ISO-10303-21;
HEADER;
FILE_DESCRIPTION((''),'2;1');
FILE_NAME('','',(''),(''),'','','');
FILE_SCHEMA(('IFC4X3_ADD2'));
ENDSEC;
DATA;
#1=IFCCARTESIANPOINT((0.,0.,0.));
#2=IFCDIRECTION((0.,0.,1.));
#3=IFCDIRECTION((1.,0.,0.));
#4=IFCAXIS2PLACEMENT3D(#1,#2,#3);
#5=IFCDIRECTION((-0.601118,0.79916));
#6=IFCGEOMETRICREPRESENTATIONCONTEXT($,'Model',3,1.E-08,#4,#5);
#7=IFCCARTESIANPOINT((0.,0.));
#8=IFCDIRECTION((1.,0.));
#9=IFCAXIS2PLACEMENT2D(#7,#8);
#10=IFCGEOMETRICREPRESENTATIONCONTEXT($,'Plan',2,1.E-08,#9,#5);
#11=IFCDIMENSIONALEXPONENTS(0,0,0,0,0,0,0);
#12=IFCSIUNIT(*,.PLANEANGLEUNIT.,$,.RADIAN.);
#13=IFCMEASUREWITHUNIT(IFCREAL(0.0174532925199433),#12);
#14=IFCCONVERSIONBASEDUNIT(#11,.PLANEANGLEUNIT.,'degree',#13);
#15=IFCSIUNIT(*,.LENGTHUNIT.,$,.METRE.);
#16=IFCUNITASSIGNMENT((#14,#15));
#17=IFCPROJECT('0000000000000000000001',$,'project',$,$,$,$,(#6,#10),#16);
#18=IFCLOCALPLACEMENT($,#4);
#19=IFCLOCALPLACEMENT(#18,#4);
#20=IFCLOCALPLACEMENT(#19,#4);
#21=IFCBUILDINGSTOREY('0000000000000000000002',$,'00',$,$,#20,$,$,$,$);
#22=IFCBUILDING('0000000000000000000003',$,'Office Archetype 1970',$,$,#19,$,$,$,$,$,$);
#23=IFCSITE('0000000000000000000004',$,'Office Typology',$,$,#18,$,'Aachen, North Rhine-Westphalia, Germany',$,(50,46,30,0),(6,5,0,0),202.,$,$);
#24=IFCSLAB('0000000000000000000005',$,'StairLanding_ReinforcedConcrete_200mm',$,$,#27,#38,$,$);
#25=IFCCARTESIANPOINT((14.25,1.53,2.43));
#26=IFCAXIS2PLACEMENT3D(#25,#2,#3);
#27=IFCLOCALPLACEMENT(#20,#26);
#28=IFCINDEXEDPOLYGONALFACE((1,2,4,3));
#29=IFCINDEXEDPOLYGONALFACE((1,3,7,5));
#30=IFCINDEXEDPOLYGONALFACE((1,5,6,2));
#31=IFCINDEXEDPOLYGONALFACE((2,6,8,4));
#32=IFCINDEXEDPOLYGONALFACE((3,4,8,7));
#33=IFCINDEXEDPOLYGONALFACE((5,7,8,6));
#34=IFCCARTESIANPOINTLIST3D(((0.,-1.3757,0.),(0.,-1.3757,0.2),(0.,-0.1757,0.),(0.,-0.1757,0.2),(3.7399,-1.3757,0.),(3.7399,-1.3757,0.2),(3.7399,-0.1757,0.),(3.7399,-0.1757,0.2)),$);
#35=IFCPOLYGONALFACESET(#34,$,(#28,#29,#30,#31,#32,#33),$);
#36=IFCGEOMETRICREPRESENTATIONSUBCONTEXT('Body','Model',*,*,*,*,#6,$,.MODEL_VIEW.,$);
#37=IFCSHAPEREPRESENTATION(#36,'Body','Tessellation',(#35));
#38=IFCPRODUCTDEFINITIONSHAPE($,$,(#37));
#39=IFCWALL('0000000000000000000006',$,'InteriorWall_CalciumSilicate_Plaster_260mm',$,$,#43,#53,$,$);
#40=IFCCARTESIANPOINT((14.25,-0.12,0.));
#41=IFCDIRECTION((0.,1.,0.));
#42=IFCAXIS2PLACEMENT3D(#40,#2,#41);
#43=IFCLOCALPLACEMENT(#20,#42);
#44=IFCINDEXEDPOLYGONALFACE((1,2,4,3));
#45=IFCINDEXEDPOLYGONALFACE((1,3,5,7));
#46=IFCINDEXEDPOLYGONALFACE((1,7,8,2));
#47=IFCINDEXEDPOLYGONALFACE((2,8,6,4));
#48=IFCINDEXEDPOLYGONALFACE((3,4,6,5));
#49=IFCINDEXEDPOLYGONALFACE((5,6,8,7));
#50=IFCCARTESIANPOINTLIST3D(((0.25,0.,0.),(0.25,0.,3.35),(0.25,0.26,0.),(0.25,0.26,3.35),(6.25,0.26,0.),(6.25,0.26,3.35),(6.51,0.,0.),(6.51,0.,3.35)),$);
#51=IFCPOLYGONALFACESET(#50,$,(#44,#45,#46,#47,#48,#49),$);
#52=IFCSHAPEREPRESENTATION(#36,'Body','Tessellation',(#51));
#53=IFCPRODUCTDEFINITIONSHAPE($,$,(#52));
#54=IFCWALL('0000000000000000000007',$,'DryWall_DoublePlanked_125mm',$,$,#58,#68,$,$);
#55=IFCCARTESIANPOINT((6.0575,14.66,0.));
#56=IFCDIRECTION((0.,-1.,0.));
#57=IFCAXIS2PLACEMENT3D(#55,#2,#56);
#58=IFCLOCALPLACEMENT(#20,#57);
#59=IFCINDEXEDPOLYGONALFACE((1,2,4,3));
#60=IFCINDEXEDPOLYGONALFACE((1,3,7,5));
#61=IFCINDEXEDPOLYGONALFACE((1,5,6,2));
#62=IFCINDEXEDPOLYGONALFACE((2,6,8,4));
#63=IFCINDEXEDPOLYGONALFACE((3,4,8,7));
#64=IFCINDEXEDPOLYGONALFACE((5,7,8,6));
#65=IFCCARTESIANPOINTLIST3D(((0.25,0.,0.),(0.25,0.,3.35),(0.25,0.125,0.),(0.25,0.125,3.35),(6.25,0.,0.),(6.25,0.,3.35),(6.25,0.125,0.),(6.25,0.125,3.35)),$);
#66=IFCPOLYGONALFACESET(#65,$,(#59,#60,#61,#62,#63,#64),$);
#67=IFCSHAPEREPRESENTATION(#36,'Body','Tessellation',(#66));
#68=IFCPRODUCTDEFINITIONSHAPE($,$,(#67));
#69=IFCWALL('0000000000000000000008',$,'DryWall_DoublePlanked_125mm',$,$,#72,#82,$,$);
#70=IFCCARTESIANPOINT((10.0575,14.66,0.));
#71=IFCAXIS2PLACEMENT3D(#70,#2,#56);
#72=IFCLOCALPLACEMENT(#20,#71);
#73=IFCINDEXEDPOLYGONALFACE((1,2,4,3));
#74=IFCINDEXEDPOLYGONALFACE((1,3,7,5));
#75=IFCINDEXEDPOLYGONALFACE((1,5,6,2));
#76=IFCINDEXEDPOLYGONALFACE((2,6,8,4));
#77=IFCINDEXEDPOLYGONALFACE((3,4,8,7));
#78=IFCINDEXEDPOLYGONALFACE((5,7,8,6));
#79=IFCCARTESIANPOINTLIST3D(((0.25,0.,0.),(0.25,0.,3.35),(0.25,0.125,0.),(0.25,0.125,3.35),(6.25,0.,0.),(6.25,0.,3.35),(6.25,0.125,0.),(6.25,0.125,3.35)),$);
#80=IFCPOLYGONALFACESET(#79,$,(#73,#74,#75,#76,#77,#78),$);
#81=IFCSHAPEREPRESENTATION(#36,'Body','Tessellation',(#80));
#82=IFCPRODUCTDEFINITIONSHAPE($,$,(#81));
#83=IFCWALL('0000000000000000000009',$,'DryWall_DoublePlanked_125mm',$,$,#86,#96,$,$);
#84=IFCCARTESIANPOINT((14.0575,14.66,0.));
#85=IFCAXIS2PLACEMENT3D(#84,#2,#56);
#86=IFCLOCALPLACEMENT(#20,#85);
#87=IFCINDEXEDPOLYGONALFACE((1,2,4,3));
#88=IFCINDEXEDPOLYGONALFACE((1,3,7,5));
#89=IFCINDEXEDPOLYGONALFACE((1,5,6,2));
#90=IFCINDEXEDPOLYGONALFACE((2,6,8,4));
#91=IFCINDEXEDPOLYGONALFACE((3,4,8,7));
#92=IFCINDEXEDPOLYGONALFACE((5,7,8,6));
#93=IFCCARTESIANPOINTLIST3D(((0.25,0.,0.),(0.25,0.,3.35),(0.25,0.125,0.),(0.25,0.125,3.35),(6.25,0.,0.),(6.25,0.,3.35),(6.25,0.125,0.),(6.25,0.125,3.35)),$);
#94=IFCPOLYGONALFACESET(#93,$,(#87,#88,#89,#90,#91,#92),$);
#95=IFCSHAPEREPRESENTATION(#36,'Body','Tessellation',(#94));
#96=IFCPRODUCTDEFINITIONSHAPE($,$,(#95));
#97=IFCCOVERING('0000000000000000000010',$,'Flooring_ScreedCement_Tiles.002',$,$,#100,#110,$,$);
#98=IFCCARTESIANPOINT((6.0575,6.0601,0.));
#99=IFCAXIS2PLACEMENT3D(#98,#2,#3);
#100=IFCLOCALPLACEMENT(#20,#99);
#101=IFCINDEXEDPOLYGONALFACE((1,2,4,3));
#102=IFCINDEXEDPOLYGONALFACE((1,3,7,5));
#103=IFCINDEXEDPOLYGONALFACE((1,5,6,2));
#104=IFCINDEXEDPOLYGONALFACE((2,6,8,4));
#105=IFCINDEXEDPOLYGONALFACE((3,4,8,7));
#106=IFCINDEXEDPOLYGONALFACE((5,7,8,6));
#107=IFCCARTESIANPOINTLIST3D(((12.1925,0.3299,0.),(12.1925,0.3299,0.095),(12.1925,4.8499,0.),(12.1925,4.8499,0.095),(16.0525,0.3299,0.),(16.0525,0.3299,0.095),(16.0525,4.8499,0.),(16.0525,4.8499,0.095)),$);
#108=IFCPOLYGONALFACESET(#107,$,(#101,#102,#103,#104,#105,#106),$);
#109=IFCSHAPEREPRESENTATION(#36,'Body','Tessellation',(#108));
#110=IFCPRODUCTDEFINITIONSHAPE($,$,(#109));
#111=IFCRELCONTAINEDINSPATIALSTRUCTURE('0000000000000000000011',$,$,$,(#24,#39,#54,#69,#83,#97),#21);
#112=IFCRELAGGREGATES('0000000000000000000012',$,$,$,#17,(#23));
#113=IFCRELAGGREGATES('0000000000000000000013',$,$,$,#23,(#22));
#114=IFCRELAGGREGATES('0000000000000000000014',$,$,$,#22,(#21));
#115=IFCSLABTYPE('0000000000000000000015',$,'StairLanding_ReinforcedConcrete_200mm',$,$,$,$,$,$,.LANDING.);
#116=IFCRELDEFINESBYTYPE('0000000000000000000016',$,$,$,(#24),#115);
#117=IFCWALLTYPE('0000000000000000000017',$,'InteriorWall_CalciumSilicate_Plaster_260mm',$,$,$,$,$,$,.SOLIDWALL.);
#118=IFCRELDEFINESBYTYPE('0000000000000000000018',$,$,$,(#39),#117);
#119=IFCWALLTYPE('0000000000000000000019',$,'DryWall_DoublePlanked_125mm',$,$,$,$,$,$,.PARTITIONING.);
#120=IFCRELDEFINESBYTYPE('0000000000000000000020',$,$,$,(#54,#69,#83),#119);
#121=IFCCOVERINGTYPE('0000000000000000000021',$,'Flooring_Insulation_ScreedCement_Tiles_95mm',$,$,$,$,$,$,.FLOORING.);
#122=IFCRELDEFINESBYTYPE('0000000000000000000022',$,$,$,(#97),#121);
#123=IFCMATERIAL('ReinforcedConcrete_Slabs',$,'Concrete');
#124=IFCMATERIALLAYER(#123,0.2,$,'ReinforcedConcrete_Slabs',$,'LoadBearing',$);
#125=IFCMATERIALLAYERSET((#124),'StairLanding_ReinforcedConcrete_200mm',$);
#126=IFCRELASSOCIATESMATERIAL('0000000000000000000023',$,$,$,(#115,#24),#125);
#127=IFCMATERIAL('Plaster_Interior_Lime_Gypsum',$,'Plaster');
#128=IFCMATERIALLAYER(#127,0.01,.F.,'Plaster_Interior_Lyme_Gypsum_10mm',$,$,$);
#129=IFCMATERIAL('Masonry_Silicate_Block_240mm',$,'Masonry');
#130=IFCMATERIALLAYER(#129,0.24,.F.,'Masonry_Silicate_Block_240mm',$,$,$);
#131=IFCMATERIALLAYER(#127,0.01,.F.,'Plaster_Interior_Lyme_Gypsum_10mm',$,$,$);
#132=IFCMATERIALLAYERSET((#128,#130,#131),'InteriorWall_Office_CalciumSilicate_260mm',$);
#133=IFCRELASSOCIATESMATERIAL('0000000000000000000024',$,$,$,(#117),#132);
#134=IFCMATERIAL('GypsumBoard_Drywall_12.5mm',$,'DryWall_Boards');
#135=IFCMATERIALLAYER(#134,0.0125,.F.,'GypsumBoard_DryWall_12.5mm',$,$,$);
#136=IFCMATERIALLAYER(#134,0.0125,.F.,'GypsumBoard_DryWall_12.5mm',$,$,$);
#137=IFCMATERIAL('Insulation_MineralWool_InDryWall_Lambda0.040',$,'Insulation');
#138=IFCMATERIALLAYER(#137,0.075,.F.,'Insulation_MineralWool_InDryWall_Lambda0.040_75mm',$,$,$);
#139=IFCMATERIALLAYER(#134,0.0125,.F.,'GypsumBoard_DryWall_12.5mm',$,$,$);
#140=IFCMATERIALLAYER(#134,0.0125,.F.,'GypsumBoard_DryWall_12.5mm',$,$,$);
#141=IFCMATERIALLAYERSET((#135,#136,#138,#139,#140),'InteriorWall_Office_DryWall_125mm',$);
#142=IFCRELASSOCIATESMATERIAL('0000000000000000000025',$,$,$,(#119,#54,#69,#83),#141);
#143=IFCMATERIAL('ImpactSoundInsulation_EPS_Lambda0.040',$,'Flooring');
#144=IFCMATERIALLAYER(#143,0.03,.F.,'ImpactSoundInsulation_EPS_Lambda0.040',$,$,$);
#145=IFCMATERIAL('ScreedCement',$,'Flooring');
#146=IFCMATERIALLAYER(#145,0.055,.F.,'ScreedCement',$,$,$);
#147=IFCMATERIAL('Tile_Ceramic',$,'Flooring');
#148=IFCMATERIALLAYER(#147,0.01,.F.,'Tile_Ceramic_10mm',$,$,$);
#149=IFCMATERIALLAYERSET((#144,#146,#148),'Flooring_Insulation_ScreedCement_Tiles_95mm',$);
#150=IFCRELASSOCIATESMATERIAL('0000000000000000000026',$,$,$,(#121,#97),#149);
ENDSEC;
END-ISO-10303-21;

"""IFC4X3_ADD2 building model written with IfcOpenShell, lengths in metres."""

from ifc_helpers import new_model, entity, si_unit, converted_unit, direction, frame, origin_with_axes, origin_2d_with_axis, place, context, subcontext, project, spatial, line, indexed_curve, outline, extrude, material, layer, layer_set, layer_usage, type_object, element, save


model = new_model("IFC4X3_ADD2")

# Units and contexts
model_context = context("Model", 3, precision=1e-08, world=origin_with_axes(), true_north=direction((-0.601118, 0.79916)))
plan_context = context("Plan", 2, precision=1e-08, world=origin_2d_with_axis(), true_north=direction((-0.601118, 0.79916)))
body_context = subcontext(model_context, "Body", "Model", "MODEL_VIEW")
ifc_project = project(units=[converted_unit("PLANEANGLEUNIT", "degree", entity("IfcReal", 0.0174532925199433), si_unit("PLANEANGLEUNIT", "RADIAN"), dimensions=[0, 0, 0, 0, 0, 0, 0]), si_unit("LENGTHUNIT", "METRE")], contexts=[model_context, plan_context])

# Site, building, storey
site_placement = place(None, origin_with_axes())
site = spatial("IfcSite", under=ifc_project, at=site_placement, Name="Office Typology", LongName="Aachen, North Rhine-Westphalia, Germany", RefLatitude=(50, 46, 30, 0), RefLongitude=(6, 5, 0, 0), RefElevation=202.0)
building_placement = place(site_placement, origin_with_axes())
building = spatial("IfcBuilding", under=site, at=building_placement, Name="Office Archetype 1970")
storey_placement = place(building_placement, origin_with_axes())
storey = spatial("IfcBuildingStorey", under=building, at=storey_placement, Name="00")

# Slab
ifc_material_1 = material(Name="ReinforcedConcrete_Slabs", Category="Concrete")
ifc_layer_1 = layer(ifc_material_1, 0.2, Name="ReinforcedConcrete_Slabs", Category="LoadBearing")
ifc_layer_set_1 = layer_set([ifc_layer_1], Name="StairLanding_ReinforcedConcrete_200mm")
ifc_layer_usage_1 = layer_usage(ifc_layer_set_1, "AXIS3", "POSITIVE", 0.0)
slab_type = type_object("IfcSlabType", Name="StairLanding_ReinforcedConcrete_200mm", PredefinedType="LANDING", material=ifc_layer_set_1)
slab_placement = place(storey_placement, frame((14.25, 1.53, 2.43), z_axis=(0.0, 0.0, 1.0), x_axis=(1.0, 0.0, 0.0)))
element("IfcSlab", 1, at=slab_placement, inside=storey, type_object=slab_type, material=ifc_layer_usage_1, Name="StairLanding_ReinforcedConcrete_200mm", context=body_context, shape_type="SweptSolid", body=[
    extrude(outline(indexed_curve([(3.7399, -0.1757), (3.7399, -1.3757), (0.0, -1.3757), (0.0, -0.1757), (3.7399, -0.1757)])), None, (0.0, 0.0, 1.0), 0.2),
])

# Shared definitions
ifc_material_2 = material(Name="Plaster_Interior_Lime_Gypsum", Category="Plaster")
ifc_layer_2 = layer(ifc_material_2, 0.01, ventilated=False, Name="Plaster_Interior_Lyme_Gypsum_10mm")
ifc_material_3 = material(Name="Masonry_Silicate_Block_240mm", Category="Masonry")
ifc_layer_3 = layer(ifc_material_3, 0.24, ventilated=False, Name="Masonry_Silicate_Block_240mm")
ifc_layer_4 = layer(ifc_material_2, 0.01, ventilated=False, Name="Plaster_Interior_Lyme_Gypsum_10mm")
ifc_layer_set_2 = layer_set([ifc_layer_2, ifc_layer_3, ifc_layer_4], Name="InteriorWall_Office_CalciumSilicate_260mm")
wall_type_1 = type_object("IfcWallType", Name="InteriorWall_CalciumSilicate_Plaster_260mm", PredefinedType="SOLIDWALL", material=ifc_layer_set_2)

# Walls
wall_1_placement = place(storey_placement, frame((14.25, -0.12, 0.0), z_axis=(0.0, 0.0, 1.0), x_axis=(0.0, 1.0, 0.0)))
element("IfcWall", 2, at=wall_1_placement, inside=storey, type_object=wall_type_1, Name="InteriorWall_CalciumSilicate_Plaster_260mm", context=body_context, shape_type="SweptSolid", body=[
    extrude(outline(indexed_curve([(0.25, 0.0), (0.25, 0.26), (6.25, 0.26), (6.51, 0.0)], segments=[line(1, 2, 3, 4, 1)])), origin_with_axes(), (0.0, 0.0, 1.0), 3.35),
])
ifc_material_4 = material(Name="GypsumBoard_Drywall_12.5mm", Category="DryWall_Boards")
ifc_layer_5 = layer(ifc_material_4, 0.0125, ventilated=False, Name="GypsumBoard_DryWall_12.5mm")
ifc_layer_6 = layer(ifc_material_4, 0.0125, ventilated=False, Name="GypsumBoard_DryWall_12.5mm")
ifc_material_5 = material(Name="Insulation_MineralWool_InDryWall_Lambda0.040", Category="Insulation")
ifc_layer_7 = layer(ifc_material_5, 0.075, ventilated=False, Name="Insulation_MineralWool_InDryWall_Lambda0.040_75mm")
ifc_layer_8 = layer(ifc_material_4, 0.0125, ventilated=False, Name="GypsumBoard_DryWall_12.5mm")
ifc_layer_9 = layer(ifc_material_4, 0.0125, ventilated=False, Name="GypsumBoard_DryWall_12.5mm")
ifc_layer_set_3 = layer_set([ifc_layer_5, ifc_layer_6, ifc_layer_7, ifc_layer_8, ifc_layer_9], Name="InteriorWall_Office_DryWall_125mm")
ifc_layer_usage_2 = layer_usage(ifc_layer_set_3, "AXIS2", "POSITIVE", 0.0)
wall_type_2 = type_object("IfcWallType", Name="DryWall_DoublePlanked_125mm", PredefinedType="PARTITIONING", material=ifc_layer_set_3)
wall_2_placement = place(storey_placement, frame((6.0575, 14.66, 0.0), z_axis=(0.0, 0.0, 1.0), x_axis=(0.0, -1.0, 0.0)))
element("IfcWall", 3, at=wall_2_placement, inside=storey, type_object=wall_type_2, material=ifc_layer_usage_2, Name="DryWall_DoublePlanked_125mm", context=body_context, shape_type="SweptSolid", body=[
    extrude(outline(indexed_curve([(0.25, 0.0), (0.25, 0.125), (6.25, 0.125), (6.25, 0.0)], segments=[line(1, 2, 3, 4, 1)])), origin_with_axes(), (0.0, 0.0, 1.0), 3.35),
])
ifc_layer_usage_3 = layer_usage(ifc_layer_set_3, "AXIS2", "POSITIVE", 0.0)
wall_3_placement = place(storey_placement, frame((10.0575, 14.66, 0.0), z_axis=(0.0, 0.0, 1.0), x_axis=(0.0, -1.0, 0.0)))
element("IfcWall", 4, at=wall_3_placement, inside=storey, type_object=wall_type_2, material=ifc_layer_usage_3, Name="DryWall_DoublePlanked_125mm", context=body_context, shape_type="SweptSolid", body=[
    extrude(outline(indexed_curve([(0.25, 0.0), (0.25, 0.125), (6.25, 0.125), (6.25, 0.0)], segments=[line(1, 2, 3, 4, 1)])), origin_with_axes(), (0.0, 0.0, 1.0), 3.35),
])
ifc_layer_usage_4 = layer_usage(ifc_layer_set_3, "AXIS2", "POSITIVE", 0.0)
wall_4_placement = place(storey_placement, frame((14.0575, 14.66, 0.0), z_axis=(0.0, 0.0, 1.0), x_axis=(0.0, -1.0, 0.0)))
element("IfcWall", 5, at=wall_4_placement, inside=storey, type_object=wall_type_2, material=ifc_layer_usage_4, Name="DryWall_DoublePlanked_125mm", context=body_context, shape_type="SweptSolid", body=[
    extrude(outline(indexed_curve([(0.25, 0.0), (0.25, 0.125), (6.25, 0.125), (6.25, 0.0)], segments=[line(1, 2, 3, 4, 1)])), origin_with_axes(), (0.0, 0.0, 1.0), 3.35),
])

# Covering
ifc_material_6 = material(Name="ImpactSoundInsulation_EPS_Lambda0.040", Category="Flooring")
ifc_layer_10 = layer(ifc_material_6, 0.03, ventilated=False, Name="ImpactSoundInsulation_EPS_Lambda0.040")
ifc_material_7 = material(Name="ScreedCement", Category="Flooring")
ifc_layer_11 = layer(ifc_material_7, 0.055, ventilated=False, Name="ScreedCement")
ifc_material_8 = material(Name="Tile_Ceramic", Category="Flooring")
ifc_layer_12 = layer(ifc_material_8, 0.01, ventilated=False, Name="Tile_Ceramic_10mm")
ifc_layer_set_4 = layer_set([ifc_layer_10, ifc_layer_11, ifc_layer_12], Name="Flooring_Insulation_ScreedCement_Tiles_95mm")
ifc_layer_usage_5 = layer_usage(ifc_layer_set_4, "AXIS3", "POSITIVE", 0.0)
covering_type = type_object("IfcCoveringType", Name="Flooring_Insulation_ScreedCement_Tiles_95mm", PredefinedType="FLOORING", material=ifc_layer_set_4)
covering_placement = place(storey_placement, frame((6.0575, 6.0601, 0.0), z_axis=(0.0, 0.0, 1.0), x_axis=(1.0, 0.0, 0.0)))
element("IfcCovering", 6, at=covering_placement, inside=storey, type_object=covering_type, material=ifc_layer_usage_5, Name="Flooring_ScreedCement_Tiles.002", context=body_context, shape_type="SweptSolid", body=[
    extrude(outline(indexed_curve([(12.1925, 0.3299), (12.1925, 4.8499), (16.0525, 4.8499), (16.0525, 0.3299)], segments=[line(1, 2, 3, 4, 1)])), origin_with_axes(), (0.0, 0.0, 1.0), 0.095),
])

save(model, "model.ifc")
